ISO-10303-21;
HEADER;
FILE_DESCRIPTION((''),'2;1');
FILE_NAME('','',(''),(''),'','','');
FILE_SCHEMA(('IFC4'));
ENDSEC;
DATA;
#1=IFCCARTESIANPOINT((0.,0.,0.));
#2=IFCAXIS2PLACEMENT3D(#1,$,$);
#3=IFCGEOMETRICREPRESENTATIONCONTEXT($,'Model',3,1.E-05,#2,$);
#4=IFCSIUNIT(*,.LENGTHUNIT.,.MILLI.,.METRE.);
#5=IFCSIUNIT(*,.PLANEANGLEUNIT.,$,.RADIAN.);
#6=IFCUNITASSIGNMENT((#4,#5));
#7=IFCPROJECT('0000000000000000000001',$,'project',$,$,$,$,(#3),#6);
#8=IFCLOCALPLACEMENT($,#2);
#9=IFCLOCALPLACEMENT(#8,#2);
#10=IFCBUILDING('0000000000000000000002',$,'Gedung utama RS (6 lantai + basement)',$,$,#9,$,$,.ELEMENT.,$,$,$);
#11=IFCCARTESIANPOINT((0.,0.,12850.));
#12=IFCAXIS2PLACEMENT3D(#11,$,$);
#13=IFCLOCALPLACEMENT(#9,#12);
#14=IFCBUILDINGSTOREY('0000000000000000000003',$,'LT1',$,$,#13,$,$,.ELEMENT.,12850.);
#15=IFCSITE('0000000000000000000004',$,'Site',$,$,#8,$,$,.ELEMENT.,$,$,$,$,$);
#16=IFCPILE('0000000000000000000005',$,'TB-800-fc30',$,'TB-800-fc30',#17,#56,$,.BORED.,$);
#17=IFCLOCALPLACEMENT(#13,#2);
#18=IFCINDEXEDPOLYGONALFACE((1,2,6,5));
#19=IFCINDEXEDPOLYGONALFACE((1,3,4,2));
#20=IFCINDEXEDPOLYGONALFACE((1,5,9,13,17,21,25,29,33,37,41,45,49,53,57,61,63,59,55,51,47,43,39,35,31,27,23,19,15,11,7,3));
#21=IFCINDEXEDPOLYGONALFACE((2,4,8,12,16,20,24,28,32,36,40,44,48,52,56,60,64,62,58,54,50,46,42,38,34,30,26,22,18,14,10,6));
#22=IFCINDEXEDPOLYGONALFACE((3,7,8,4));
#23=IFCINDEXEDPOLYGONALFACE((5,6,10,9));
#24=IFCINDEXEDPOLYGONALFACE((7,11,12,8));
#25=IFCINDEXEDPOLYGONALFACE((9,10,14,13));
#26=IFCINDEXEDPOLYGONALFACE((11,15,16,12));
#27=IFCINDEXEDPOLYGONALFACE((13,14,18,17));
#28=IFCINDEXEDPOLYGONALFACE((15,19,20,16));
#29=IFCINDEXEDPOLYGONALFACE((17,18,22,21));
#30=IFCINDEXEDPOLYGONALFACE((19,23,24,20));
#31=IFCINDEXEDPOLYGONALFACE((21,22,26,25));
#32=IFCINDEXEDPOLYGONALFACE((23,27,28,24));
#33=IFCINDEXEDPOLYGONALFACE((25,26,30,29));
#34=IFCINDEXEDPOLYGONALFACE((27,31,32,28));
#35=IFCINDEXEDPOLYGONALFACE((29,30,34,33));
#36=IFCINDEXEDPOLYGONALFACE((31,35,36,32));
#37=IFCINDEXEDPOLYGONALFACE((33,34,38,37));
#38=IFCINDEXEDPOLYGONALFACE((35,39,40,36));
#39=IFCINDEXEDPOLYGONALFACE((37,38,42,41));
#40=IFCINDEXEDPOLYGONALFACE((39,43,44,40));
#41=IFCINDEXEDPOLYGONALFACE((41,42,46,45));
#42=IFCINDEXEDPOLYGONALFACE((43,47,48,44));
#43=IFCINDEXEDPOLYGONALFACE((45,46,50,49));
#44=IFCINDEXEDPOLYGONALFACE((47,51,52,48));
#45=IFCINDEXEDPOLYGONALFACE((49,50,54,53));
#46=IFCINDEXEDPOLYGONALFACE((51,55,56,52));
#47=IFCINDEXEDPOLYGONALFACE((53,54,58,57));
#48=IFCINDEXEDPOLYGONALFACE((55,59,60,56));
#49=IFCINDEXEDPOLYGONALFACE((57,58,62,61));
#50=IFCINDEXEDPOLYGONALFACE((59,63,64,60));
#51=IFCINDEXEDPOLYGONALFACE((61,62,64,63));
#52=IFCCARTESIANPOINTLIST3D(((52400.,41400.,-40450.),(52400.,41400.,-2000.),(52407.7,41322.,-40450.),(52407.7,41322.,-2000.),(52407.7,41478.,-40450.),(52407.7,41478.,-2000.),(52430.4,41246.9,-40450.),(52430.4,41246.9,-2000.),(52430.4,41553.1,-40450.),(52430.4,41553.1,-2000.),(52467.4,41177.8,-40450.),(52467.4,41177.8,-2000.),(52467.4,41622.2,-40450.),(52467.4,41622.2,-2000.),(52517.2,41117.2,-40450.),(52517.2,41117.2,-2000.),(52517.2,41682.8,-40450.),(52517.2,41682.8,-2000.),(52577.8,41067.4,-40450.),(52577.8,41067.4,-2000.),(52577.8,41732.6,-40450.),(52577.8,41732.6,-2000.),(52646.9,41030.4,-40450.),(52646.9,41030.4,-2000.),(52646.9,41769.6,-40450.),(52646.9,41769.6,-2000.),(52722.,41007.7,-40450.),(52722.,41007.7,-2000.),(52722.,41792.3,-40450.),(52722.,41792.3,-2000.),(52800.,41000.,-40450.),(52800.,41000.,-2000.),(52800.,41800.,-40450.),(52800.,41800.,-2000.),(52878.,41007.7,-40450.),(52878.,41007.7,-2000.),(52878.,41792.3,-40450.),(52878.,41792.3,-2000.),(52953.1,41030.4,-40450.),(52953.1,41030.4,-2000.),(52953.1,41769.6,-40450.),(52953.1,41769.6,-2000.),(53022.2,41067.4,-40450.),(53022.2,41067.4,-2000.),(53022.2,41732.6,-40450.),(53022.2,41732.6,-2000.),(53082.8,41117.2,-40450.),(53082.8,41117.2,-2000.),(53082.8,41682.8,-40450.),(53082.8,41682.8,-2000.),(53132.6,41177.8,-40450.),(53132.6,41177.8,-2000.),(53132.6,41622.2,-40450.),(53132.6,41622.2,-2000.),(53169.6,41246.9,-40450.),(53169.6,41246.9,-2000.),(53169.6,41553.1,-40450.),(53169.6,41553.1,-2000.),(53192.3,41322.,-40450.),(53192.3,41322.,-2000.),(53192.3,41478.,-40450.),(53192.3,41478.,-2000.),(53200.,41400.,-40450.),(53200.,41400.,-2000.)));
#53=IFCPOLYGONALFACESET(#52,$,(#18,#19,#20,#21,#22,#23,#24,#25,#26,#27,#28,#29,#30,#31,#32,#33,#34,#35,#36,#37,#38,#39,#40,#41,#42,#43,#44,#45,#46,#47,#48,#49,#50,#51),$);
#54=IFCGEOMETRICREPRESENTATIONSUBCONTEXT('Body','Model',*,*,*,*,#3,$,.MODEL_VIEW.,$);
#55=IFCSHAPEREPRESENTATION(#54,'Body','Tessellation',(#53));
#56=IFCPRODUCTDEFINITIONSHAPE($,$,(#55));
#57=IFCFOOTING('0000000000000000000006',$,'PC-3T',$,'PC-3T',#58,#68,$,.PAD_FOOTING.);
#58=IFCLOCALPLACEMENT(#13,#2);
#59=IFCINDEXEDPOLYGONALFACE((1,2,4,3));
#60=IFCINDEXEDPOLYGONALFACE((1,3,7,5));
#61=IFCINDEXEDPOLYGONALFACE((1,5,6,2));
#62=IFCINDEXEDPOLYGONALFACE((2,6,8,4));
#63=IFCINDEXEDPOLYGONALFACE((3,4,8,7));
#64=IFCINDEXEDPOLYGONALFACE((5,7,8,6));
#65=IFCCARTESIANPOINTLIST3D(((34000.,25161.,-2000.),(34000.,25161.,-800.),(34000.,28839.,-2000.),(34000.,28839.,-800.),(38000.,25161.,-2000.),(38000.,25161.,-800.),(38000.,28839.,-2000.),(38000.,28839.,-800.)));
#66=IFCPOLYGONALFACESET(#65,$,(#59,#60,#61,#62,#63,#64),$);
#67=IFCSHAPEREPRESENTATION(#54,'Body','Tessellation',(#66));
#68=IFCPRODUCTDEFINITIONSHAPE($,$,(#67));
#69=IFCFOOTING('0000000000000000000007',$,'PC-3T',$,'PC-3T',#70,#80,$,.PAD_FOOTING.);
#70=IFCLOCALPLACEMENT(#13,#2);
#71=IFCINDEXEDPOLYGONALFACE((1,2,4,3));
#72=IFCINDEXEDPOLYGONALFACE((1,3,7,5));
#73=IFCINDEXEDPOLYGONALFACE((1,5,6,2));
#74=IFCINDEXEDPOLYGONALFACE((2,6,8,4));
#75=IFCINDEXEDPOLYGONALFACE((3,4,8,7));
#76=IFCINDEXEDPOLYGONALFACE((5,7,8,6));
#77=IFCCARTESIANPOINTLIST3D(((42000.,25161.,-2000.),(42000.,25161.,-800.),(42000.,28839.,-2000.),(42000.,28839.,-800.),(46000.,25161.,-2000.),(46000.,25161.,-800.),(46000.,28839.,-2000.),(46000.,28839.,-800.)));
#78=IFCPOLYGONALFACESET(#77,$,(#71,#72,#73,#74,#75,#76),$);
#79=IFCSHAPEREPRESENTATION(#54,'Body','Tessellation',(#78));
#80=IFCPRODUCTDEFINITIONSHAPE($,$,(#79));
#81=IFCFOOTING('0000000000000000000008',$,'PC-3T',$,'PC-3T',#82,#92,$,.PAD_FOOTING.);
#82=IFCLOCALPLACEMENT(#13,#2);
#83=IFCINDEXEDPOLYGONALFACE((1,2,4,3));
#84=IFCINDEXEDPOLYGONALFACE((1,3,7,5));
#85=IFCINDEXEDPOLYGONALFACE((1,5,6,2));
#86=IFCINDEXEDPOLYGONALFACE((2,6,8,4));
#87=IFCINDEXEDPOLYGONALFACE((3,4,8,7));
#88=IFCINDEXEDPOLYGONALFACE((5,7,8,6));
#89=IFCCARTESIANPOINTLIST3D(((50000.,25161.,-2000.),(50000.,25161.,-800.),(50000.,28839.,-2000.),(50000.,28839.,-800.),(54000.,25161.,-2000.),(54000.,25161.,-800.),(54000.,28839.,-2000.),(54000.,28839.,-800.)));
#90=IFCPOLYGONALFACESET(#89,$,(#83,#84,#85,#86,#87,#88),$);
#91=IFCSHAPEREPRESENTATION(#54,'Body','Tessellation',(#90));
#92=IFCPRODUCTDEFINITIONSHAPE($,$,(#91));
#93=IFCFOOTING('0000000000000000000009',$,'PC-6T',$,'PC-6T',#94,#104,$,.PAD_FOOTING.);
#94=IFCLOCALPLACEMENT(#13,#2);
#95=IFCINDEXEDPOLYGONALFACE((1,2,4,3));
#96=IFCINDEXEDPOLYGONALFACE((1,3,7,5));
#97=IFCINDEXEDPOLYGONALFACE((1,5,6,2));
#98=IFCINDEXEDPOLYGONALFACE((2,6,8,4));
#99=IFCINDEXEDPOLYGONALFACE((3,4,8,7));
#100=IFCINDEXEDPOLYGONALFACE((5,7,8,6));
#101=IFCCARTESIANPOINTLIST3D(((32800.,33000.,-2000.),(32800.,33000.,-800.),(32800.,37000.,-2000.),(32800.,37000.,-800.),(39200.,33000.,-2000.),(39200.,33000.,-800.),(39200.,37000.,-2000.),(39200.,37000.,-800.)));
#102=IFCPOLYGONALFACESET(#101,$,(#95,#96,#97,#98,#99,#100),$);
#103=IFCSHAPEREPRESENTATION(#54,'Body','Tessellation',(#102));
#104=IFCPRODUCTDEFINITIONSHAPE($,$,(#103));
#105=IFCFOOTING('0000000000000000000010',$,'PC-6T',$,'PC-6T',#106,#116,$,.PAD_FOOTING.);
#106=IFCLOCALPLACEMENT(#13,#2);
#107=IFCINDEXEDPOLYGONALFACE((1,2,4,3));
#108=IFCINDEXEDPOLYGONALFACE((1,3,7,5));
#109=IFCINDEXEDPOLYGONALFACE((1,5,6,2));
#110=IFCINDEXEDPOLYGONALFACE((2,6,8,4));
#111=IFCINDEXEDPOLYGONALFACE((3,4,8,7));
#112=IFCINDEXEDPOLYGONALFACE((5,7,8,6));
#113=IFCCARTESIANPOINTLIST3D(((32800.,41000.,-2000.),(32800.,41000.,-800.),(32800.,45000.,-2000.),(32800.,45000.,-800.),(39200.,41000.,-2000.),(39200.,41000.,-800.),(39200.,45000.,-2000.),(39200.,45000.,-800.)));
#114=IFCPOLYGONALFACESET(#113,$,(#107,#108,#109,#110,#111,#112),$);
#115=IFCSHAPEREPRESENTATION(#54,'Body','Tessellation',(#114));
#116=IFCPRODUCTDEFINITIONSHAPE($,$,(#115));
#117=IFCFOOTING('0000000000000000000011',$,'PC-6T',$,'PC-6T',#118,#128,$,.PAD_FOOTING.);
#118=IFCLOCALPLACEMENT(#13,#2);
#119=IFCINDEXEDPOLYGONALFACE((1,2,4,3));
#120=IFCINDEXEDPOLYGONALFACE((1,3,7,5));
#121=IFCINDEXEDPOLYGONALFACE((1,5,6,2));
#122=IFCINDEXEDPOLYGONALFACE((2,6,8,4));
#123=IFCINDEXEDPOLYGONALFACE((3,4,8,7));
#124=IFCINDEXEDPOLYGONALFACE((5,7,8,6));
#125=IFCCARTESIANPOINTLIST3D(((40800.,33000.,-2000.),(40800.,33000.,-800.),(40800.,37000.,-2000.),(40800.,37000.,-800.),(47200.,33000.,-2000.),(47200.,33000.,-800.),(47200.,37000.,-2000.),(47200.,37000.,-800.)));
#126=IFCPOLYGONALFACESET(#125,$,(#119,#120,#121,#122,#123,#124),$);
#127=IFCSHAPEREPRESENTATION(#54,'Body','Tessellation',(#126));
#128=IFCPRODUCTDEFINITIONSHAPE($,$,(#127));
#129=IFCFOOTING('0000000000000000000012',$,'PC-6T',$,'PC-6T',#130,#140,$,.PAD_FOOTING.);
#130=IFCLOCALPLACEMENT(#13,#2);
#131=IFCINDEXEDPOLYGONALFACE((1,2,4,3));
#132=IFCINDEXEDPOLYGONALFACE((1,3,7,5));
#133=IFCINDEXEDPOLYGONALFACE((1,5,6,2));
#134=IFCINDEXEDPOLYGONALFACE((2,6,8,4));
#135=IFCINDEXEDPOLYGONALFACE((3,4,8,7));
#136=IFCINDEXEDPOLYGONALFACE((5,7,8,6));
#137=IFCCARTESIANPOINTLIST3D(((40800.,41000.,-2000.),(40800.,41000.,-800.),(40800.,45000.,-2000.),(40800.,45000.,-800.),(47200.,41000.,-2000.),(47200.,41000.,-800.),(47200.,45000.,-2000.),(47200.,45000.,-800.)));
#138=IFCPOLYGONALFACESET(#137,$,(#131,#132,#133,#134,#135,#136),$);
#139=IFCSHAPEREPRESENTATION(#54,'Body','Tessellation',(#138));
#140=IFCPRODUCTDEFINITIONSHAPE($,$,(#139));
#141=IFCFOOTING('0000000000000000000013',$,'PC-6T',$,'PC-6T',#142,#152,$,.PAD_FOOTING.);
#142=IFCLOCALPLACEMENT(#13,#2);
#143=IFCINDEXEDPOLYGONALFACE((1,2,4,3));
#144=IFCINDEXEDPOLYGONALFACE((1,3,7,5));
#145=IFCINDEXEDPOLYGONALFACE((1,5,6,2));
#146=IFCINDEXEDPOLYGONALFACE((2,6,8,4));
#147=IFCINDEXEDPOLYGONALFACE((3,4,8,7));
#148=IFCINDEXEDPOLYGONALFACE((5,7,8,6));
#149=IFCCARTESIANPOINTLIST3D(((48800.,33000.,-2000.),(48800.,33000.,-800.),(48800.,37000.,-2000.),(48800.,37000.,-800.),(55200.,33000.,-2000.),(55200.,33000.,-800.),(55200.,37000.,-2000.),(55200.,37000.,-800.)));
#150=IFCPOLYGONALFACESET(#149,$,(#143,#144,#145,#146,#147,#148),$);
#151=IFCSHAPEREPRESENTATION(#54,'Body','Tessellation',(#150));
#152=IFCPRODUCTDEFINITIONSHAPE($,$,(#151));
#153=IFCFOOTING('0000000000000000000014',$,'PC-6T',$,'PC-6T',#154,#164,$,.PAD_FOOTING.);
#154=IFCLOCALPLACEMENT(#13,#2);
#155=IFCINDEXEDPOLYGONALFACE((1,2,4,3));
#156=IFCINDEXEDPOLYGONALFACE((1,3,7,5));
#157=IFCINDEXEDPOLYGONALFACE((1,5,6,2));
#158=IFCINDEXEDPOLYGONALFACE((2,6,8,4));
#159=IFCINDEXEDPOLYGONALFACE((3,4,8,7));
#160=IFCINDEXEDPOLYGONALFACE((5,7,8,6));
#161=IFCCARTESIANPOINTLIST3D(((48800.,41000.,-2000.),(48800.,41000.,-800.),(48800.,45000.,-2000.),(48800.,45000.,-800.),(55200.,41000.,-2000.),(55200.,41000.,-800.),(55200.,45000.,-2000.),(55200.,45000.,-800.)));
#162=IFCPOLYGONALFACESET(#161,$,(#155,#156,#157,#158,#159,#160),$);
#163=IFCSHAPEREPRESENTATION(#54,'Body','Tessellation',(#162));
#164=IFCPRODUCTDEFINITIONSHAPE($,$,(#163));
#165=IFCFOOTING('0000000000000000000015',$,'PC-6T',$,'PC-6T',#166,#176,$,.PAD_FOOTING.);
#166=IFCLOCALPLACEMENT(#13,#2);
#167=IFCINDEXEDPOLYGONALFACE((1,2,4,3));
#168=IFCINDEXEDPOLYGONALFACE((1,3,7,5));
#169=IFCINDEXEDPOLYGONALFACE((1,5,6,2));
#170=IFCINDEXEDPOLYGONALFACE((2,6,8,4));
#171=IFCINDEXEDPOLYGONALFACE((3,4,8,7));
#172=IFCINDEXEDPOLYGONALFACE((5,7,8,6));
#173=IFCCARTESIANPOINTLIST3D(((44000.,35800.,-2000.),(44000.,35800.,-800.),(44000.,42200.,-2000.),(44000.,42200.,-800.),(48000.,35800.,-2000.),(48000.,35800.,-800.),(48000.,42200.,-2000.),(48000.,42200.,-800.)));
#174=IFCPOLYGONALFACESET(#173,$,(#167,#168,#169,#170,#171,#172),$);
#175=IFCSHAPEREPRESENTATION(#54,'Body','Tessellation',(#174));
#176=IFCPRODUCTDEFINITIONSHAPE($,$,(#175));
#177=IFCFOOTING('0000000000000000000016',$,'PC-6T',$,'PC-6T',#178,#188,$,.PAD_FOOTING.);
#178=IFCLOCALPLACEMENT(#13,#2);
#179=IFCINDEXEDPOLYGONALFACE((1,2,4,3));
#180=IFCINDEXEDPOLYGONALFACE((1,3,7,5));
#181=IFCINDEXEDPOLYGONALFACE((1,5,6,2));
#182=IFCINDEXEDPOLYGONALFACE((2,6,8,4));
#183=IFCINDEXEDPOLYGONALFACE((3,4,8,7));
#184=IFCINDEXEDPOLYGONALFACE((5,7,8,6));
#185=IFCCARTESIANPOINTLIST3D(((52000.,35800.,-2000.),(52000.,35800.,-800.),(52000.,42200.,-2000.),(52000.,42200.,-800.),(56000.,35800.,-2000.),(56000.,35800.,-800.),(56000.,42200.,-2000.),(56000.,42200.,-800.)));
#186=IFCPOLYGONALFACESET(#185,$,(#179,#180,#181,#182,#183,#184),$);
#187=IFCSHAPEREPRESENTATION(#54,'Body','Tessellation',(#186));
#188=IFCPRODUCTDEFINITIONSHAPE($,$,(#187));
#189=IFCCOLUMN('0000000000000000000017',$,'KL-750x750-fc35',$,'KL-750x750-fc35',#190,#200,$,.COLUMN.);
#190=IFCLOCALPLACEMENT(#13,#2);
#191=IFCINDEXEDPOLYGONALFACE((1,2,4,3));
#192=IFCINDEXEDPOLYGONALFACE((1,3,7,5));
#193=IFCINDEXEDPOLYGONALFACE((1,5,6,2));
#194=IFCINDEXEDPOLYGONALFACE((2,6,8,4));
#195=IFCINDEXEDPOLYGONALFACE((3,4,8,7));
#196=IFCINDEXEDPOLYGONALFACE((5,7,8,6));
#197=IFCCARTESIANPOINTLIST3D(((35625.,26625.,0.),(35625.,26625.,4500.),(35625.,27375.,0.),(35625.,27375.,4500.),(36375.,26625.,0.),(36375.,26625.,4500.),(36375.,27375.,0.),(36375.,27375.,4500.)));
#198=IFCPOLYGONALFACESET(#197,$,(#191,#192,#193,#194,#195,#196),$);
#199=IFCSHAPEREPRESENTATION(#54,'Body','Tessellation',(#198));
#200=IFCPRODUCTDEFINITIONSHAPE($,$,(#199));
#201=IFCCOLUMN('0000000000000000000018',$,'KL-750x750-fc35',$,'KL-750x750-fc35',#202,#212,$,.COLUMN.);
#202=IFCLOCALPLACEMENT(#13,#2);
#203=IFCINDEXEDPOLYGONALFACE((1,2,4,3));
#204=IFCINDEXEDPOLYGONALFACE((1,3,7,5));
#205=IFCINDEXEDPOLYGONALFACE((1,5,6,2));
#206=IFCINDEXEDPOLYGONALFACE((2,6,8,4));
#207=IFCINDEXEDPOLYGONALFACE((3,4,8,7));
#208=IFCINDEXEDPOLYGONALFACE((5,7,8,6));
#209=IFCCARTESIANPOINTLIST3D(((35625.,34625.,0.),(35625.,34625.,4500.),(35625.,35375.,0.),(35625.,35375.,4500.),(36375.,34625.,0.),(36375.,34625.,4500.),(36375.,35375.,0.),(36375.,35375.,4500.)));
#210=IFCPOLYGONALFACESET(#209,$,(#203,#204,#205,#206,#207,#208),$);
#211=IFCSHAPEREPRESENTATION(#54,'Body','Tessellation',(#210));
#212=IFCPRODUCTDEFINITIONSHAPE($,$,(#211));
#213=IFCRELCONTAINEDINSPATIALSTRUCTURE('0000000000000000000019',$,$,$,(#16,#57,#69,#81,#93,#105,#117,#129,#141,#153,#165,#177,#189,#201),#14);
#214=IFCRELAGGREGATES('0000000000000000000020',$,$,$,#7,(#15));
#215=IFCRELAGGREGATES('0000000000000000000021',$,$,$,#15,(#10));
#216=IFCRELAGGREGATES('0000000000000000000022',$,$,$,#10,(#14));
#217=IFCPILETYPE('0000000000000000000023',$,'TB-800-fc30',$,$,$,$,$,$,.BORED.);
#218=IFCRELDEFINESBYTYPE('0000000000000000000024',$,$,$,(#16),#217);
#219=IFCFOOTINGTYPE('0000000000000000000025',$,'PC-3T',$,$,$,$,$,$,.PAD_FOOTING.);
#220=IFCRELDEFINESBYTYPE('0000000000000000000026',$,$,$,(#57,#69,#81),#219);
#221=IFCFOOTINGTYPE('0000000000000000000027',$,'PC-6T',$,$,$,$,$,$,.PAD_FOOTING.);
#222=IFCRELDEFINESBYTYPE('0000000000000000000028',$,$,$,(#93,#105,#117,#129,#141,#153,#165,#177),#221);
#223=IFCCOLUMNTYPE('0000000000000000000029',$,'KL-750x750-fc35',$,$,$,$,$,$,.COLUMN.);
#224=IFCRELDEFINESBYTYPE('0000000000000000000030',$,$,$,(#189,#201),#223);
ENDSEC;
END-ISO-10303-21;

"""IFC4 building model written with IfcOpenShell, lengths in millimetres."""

from ifc_helpers import new_model, si_unit, frame, origin, origin_2d, place, context, subcontext, project, spatial, rectangle, circle, extrude, material_profile, profile_set, profile_usage, type_object, element, save


model = new_model("IFC4")

# Units and contexts
model_context = context("Model", 3, precision=1e-05, world=origin())
body_context = subcontext(model_context, "Body", "Model", "MODEL_VIEW")
ifc_project = project(units=[si_unit("LENGTHUNIT", "METRE", prefix="MILLI"), si_unit("PLANEANGLEUNIT", "RADIAN")], contexts=[model_context])

# Site, building, storey
site_placement = place(None, origin())
site = spatial("IfcSite", under=ifc_project, at=site_placement, Name="Site", CompositionType="ELEMENT")
building_placement = place(site_placement, origin())
building = spatial("IfcBuilding", under=site, at=building_placement, Name="Gedung utama RS (6 lantai + basement)", CompositionType="ELEMENT")
storey_placement = place(building_placement, frame((0.0, 0.0, 12850.0)))
storey = spatial("IfcBuildingStorey", under=building, at=storey_placement, Name="LT1", CompositionType="ELEMENT", Elevation=12850.0)

# Pile
ifc_material_profile_1 = material_profile(None, circle(Radius=400.0, at=origin_2d()), Name="TB-800-fc30")
ifc_profile_set_1 = profile_set([ifc_material_profile_1], Name="TB-800-fc30")
ifc_profile_usage_1 = profile_usage(ifc_profile_set_1, cardinal=5)
pile_type = type_object("IfcPileType", Name="TB-800-fc30", PredefinedType="BORED", material=ifc_profile_set_1)
for number, where, z_axis, x_axis, name in (
    (1, (52800.0, 41400.0, -40450.0), (0.0, 0.0, 1.0), (1.0, 0.0, 0.0), "TB-800-fc30"),
):
    element("IfcPile", number, at=place(storey_placement, frame(where, z_axis=z_axis, x_axis=x_axis)), inside=storey, type_object=pile_type, material=ifc_profile_usage_1, Name=name, ObjectType="TB-800-fc30", PredefinedType="BORED", context=body_context, shape_type="SweptSolid", body=[
        extrude(circle(Radius=400.0, at=origin_2d()), origin(), (0.0, 0.0, 1.0), 38450.0),
    ])

# Footings
ifc_material_profile_2 = material_profile(None, rectangle(XDim=4000.0, YDim=3678.0, at=origin_2d()), Name="PC-3T")
ifc_profile_set_2 = profile_set([ifc_material_profile_2], Name="PC-3T")
ifc_profile_usage_2 = profile_usage(ifc_profile_set_2, cardinal=5)
footing_type_1 = type_object("IfcFootingType", Name="PC-3T", PredefinedType="PAD_FOOTING", material=ifc_profile_set_2)
for number, where, z_axis, x_axis, name in (
    (2, (36000.0, 27000.0, -2000.0), (0.0, 0.0, 1.0), (1.0, 0.0, 0.0), "PC-3T"),
    (3, (44000.0, 27000.0, -2000.0), (0.0, 0.0, 1.0), (1.0, 0.0, 0.0), "PC-3T"),
    (4, (52000.0, 27000.0, -2000.0), (0.0, 0.0, 1.0), (1.0, 0.0, 0.0), "PC-3T"),
):
    element("IfcFooting", number, at=place(storey_placement, frame(where, z_axis=z_axis, x_axis=x_axis)), inside=storey, type_object=footing_type_1, material=ifc_profile_usage_2, Name=name, ObjectType="PC-3T", PredefinedType="PAD_FOOTING", context=body_context, shape_type="SweptSolid", body=[
        extrude(rectangle(XDim=4000.0, YDim=3678.0, at=origin_2d()), origin(), (0.0, 0.0, 1.0), 1200.0),
    ])
ifc_material_profile_3 = material_profile(None, rectangle(XDim=6400.0, YDim=4000.0, at=origin_2d()), Name="PC-6T")
ifc_profile_set_3 = profile_set([ifc_material_profile_3], Name="PC-6T")
ifc_profile_usage_3 = profile_usage(ifc_profile_set_3, cardinal=5)
footing_type_2 = type_object("IfcFootingType", Name="PC-6T", PredefinedType="PAD_FOOTING", material=ifc_profile_set_3)
for number, where, z_axis, x_axis, name in (
    (5, (36000.0, 35000.0, -2000.0), (0.0, 0.0, 1.0), (1.0, 0.0, 0.0), "PC-6T"),
    (6, (36000.0, 43000.0, -2000.0), (0.0, 0.0, 1.0), (1.0, 0.0, 0.0), "PC-6T"),
    (7, (44000.0, 35000.0, -2000.0), (0.0, 0.0, 1.0), (1.0, 0.0, 0.0), "PC-6T"),
    (8, (44000.0, 43000.0, -2000.0), (0.0, 0.0, 1.0), (1.0, 0.0, 0.0), "PC-6T"),
    (9, (52000.0, 35000.0, -2000.0), (0.0, 0.0, 1.0), (1.0, 0.0, 0.0), "PC-6T"),
    (10, (52000.0, 43000.0, -2000.0), (0.0, 0.0, 1.0), (1.0, 0.0, 0.0), "PC-6T"),
    (11, (46000.0, 39000.0, -2000.0), (0.0, 0.0, 1.0), (0.0, 1.0, 0.0), "PC-6T"),
    (12, (54000.0, 39000.0, -2000.0), (0.0, 0.0, 1.0), (0.0, 1.0, 0.0), "PC-6T"),
):
    element("IfcFooting", number, at=place(storey_placement, frame(where, z_axis=z_axis, x_axis=x_axis)), inside=storey, type_object=footing_type_2, material=ifc_profile_usage_3, Name=name, ObjectType="PC-6T", PredefinedType="PAD_FOOTING", context=body_context, shape_type="SweptSolid", body=[
        extrude(rectangle(XDim=6400.0, YDim=4000.0, at=origin_2d()), origin(), (0.0, 0.0, 1.0), 1200.0),
    ])

# Columns
ifc_material_profile_4 = material_profile(None, rectangle(XDim=750.0, YDim=750.0, at=origin_2d()), Name="KL-750x750-fc35")
ifc_profile_set_4 = profile_set([ifc_material_profile_4], Name="KL-750x750-fc35")
ifc_profile_usage_4 = profile_usage(ifc_profile_set_4, cardinal=5)
column_type = type_object("IfcColumnType", Name="KL-750x750-fc35", PredefinedType="COLUMN", material=ifc_profile_set_4)
for number, where, z_axis, x_axis, name in (
    (13, (36000.0, 27000.0, 0.0), (0.0, 0.0, 1.0), (1.0, 0.0, 0.0), "KL-750x750-fc35"),
    (14, (36000.0, 35000.0, 0.0), (0.0, 0.0, 1.0), (1.0, 0.0, 0.0), "KL-750x750-fc35"),
):
    element("IfcColumn", number, at=place(storey_placement, frame(where, z_axis=z_axis, x_axis=x_axis)), inside=storey, type_object=column_type, material=ifc_profile_usage_4, Name=name, ObjectType="KL-750x750-fc35", PredefinedType="COLUMN", context=body_context, shape_type="SweptSolid", body=[
        extrude(rectangle(XDim=750.0, YDim=750.0, at=origin_2d()), origin(), (0.0, 0.0, 1.0), 4500.0),
    ])

save(model, "model.ifc")
